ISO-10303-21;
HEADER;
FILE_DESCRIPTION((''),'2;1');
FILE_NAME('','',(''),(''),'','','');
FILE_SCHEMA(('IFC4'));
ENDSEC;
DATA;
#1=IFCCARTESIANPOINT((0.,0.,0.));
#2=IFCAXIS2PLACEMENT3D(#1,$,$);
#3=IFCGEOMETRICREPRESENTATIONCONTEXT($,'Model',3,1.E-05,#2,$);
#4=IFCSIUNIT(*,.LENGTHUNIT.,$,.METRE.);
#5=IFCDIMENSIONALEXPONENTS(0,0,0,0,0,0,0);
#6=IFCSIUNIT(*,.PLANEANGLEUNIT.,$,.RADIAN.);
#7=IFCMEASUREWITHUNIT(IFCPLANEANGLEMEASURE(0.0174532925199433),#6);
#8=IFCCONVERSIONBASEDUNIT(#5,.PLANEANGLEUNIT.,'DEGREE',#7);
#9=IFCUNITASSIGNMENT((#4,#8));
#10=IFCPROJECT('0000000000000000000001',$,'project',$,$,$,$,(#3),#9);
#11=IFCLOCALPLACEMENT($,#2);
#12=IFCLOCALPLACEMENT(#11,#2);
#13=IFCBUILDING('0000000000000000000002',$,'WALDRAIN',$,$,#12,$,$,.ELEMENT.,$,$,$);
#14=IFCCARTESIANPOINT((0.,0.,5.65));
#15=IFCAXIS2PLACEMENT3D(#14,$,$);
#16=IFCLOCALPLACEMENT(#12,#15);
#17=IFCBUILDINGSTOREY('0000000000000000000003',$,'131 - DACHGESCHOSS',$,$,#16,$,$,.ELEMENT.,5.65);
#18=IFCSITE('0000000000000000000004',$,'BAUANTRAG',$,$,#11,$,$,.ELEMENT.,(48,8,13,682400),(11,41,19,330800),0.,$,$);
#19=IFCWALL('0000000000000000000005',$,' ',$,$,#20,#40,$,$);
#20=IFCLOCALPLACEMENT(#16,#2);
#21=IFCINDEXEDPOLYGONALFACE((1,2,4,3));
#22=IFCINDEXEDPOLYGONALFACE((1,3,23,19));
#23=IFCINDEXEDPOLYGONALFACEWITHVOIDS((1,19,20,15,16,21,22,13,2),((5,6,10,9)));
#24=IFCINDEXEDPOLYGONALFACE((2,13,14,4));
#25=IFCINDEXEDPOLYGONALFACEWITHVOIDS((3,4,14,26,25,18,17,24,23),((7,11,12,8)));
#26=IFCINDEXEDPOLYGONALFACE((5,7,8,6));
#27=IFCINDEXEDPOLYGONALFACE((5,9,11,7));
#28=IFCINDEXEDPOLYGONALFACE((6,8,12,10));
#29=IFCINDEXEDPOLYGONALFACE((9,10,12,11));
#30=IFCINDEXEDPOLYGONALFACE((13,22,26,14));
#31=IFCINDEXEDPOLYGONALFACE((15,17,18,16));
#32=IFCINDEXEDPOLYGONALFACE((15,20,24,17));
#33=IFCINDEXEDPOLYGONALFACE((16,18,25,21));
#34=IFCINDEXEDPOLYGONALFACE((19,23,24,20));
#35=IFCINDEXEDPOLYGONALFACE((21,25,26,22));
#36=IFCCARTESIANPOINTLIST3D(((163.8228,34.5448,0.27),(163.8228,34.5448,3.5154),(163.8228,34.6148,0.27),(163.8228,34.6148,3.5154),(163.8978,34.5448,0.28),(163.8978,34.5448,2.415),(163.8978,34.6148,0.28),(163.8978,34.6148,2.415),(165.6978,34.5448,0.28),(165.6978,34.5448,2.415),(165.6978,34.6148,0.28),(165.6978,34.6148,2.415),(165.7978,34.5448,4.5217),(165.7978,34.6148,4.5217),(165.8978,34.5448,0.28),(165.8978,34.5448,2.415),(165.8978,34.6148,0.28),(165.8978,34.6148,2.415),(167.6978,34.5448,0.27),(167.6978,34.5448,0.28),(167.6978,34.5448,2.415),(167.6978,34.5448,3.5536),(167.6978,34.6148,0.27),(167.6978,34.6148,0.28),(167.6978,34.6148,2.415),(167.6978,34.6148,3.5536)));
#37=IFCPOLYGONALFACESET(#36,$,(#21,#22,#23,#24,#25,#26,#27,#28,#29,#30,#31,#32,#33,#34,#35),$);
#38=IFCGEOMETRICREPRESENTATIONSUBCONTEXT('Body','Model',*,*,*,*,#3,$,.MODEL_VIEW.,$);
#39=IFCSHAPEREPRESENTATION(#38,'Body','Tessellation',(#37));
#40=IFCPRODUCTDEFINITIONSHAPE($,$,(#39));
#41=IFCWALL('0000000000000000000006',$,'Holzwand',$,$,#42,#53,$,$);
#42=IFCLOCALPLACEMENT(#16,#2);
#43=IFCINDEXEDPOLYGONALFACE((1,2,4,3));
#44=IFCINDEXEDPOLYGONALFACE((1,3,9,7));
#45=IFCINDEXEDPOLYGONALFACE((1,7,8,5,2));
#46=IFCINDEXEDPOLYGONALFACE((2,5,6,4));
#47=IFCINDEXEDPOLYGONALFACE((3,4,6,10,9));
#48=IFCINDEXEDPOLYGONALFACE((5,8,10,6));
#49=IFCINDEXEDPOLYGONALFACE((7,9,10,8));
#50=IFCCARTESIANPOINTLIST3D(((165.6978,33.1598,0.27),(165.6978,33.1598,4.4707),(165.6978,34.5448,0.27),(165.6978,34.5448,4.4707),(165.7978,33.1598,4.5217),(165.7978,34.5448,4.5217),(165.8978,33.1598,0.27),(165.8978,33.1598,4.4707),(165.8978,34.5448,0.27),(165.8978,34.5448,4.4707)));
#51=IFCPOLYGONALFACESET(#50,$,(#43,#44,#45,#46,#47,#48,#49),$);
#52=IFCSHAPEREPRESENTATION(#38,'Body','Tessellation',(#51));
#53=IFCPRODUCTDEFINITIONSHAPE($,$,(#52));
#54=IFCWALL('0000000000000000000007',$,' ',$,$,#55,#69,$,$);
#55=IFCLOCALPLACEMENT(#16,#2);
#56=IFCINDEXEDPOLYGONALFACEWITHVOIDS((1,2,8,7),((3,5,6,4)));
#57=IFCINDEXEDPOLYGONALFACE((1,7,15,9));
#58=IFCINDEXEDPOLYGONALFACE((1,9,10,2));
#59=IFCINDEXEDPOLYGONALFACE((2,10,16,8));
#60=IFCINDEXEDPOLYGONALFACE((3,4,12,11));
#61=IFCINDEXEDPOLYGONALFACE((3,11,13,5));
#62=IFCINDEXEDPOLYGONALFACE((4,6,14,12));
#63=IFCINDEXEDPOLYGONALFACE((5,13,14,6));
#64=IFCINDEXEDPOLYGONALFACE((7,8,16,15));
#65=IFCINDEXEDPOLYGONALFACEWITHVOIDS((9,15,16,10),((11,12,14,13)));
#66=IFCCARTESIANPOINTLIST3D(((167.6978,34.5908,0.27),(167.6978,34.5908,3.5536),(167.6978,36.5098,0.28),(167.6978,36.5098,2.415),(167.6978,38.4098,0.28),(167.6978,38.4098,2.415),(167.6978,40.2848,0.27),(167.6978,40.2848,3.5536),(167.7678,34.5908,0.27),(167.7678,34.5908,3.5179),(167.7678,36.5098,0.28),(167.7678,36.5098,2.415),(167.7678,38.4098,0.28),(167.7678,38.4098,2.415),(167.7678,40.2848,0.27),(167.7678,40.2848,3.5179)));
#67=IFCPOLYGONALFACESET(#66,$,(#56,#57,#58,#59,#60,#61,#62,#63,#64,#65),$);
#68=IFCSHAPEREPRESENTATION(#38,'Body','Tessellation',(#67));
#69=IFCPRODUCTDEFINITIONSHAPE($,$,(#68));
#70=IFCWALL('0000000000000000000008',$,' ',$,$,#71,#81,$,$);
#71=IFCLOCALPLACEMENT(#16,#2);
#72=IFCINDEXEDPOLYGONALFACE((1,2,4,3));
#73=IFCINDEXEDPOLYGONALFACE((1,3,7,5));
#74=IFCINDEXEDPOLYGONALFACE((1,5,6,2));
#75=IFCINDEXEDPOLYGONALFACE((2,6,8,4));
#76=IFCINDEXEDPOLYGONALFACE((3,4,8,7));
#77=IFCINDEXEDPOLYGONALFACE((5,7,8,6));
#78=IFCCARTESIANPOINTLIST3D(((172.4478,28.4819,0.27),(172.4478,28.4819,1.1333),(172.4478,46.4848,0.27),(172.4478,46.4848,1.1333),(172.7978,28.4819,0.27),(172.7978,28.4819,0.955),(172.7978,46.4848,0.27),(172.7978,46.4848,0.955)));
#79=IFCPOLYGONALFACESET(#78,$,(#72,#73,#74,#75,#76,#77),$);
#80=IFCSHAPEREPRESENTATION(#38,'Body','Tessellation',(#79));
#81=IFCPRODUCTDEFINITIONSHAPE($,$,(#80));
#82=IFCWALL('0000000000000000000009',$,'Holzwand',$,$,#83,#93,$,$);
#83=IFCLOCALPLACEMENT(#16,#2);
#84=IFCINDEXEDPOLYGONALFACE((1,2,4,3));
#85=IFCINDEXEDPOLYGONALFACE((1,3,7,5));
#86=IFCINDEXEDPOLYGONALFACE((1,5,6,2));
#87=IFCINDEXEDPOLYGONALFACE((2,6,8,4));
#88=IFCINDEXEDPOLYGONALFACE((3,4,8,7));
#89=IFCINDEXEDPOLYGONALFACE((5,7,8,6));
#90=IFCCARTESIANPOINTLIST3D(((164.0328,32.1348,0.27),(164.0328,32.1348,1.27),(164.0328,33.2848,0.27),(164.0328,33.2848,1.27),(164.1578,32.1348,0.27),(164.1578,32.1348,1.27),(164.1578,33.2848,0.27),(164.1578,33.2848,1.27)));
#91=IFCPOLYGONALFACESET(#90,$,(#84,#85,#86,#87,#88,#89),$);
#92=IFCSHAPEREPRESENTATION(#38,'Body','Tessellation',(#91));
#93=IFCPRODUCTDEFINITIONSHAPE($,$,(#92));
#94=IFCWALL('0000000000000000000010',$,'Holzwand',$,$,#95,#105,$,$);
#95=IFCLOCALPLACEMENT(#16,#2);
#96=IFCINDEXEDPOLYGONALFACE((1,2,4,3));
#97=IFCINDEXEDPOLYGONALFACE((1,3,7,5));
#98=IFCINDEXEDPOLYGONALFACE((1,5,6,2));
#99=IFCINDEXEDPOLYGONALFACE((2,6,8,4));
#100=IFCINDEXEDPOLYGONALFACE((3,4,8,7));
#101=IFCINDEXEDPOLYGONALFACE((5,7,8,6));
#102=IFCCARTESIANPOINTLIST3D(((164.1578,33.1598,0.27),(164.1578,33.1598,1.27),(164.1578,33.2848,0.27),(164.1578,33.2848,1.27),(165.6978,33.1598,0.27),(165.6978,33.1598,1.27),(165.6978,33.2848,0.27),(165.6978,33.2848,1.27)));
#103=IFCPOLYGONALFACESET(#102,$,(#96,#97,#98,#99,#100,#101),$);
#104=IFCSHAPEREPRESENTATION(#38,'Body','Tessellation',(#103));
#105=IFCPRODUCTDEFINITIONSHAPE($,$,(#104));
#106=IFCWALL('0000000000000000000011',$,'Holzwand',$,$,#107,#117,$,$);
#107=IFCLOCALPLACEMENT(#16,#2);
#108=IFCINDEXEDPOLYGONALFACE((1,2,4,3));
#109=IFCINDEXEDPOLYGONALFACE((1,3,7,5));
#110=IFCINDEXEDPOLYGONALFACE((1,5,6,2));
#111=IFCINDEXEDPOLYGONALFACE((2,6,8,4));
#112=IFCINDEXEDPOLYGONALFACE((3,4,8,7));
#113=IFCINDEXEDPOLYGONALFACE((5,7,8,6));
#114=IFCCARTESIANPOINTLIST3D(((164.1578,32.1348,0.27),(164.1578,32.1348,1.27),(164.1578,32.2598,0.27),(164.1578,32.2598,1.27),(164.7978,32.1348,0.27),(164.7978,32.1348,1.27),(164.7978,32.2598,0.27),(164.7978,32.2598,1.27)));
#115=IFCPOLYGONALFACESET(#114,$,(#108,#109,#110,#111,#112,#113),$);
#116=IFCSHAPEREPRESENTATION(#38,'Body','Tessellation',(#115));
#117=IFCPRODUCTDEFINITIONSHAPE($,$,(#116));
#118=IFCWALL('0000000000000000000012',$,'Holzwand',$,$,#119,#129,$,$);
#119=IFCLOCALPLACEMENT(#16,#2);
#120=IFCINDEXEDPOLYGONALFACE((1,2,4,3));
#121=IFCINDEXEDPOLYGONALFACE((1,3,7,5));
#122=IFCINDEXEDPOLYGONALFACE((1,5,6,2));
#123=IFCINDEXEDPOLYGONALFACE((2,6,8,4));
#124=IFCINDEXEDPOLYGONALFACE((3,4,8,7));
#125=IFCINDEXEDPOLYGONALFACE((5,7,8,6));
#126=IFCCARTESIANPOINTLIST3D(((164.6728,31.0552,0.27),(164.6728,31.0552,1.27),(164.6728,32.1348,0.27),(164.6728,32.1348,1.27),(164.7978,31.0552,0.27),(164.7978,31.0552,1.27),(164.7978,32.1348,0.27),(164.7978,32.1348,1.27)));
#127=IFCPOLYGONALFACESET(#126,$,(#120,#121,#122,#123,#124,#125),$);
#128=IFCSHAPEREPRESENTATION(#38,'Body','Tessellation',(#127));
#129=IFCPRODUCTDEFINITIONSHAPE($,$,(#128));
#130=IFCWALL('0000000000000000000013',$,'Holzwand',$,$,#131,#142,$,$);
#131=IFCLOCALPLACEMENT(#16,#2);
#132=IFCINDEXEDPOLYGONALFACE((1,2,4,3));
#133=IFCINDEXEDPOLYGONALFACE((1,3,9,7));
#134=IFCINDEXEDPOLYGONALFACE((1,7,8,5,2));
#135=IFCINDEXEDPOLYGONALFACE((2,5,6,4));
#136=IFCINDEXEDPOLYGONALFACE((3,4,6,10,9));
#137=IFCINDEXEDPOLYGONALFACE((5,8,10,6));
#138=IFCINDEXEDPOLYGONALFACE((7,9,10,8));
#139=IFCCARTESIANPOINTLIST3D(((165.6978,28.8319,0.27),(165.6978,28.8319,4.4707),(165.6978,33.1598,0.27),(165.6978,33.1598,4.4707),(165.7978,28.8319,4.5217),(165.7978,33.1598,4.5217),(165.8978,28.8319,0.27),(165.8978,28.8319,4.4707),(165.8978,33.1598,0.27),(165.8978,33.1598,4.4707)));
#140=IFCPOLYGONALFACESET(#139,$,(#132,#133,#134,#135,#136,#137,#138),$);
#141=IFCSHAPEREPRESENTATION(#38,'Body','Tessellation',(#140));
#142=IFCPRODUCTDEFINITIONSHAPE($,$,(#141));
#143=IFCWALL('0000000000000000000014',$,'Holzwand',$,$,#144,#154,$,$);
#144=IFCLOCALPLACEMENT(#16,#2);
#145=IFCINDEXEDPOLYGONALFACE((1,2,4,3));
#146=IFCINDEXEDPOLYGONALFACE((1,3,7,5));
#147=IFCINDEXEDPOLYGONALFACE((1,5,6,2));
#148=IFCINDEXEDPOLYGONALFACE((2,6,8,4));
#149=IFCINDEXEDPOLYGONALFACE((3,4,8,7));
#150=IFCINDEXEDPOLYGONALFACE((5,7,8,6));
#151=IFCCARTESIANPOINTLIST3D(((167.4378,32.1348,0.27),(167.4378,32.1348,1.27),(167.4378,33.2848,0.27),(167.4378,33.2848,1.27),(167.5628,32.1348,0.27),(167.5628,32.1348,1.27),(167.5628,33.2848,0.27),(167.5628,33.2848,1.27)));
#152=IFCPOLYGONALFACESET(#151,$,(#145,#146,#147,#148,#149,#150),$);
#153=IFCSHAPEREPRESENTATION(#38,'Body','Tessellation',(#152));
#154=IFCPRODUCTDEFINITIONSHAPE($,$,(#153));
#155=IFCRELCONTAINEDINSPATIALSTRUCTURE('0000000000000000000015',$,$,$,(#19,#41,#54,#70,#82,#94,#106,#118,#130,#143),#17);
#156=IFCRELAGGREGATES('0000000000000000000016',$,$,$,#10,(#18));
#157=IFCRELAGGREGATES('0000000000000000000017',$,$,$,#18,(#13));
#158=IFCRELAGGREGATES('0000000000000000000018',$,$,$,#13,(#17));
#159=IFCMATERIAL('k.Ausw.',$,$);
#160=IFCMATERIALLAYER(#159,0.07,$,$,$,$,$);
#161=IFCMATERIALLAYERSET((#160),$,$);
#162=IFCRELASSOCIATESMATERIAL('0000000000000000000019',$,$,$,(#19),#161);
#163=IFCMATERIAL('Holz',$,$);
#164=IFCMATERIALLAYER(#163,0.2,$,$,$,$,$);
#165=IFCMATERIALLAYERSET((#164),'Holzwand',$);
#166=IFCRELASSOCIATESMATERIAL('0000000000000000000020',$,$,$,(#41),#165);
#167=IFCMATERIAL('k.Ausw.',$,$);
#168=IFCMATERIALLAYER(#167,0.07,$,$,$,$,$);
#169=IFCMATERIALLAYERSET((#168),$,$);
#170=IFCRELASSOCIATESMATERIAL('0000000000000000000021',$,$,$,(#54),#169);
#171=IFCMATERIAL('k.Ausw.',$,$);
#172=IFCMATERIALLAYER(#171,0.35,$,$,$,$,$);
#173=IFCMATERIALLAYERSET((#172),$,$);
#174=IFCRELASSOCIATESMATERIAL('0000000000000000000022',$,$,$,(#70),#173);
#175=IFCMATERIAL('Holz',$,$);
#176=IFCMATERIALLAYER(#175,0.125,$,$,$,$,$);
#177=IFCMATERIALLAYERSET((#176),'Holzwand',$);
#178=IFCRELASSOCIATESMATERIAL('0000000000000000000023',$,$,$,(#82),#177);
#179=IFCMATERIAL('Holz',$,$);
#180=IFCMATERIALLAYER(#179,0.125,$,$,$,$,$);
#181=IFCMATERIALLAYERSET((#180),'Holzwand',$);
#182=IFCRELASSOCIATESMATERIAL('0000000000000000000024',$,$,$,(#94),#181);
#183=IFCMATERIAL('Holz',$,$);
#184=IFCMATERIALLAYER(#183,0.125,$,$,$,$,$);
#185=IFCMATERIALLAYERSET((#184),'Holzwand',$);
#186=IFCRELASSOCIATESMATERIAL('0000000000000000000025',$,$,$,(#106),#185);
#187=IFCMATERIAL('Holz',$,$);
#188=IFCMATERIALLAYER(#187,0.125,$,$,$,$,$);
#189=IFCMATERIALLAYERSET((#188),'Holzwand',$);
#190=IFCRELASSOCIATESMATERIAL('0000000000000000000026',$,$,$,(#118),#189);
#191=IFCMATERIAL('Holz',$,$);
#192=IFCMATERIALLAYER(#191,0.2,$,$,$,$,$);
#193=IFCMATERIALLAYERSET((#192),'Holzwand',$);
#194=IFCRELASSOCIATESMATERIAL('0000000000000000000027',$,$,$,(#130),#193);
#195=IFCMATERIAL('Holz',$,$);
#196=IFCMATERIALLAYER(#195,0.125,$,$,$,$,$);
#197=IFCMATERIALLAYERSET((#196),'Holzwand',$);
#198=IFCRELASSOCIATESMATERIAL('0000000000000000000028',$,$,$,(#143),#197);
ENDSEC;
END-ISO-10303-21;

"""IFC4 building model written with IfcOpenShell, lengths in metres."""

from ifc_helpers import new_model, entity, si_unit, converted_unit, frame, frame_2d, origin, origin_with_axes, place, context, subcontext, project, spatial, polyline, rectangle, outline, extrude, clip, halfspace, bounded_halfspace, material, layer, layer_set, layer_usage, element, save


model = new_model("IFC4")

# Units and contexts
model_context = context("Model", 3, precision=1e-05, world=origin())
body_context = subcontext(model_context, "Body", "Model", "MODEL_VIEW")
ifc_project = project(units=[si_unit("LENGTHUNIT", "METRE"), converted_unit("PLANEANGLEUNIT", "DEGREE", entity("IfcPlaneAngleMeasure", 0.0174532925199433), si_unit("PLANEANGLEUNIT", "RADIAN"), dimensions=[0, 0, 0, 0, 0, 0, 0])], contexts=[model_context])

# Site, building, storey
site_placement = place(None, origin())
site = spatial("IfcSite", under=ifc_project, at=site_placement, Name="BAUANTRAG", CompositionType="ELEMENT", RefLatitude=(48, 8, 13, 682400), RefLongitude=(11, 41, 19, 330800), RefElevation=0.0)
building_placement = place(site_placement, origin())
building = spatial("IfcBuilding", under=site, at=building_placement, Name="WALDRAIN", CompositionType="ELEMENT")
storey_placement = place(building_placement, frame((0.0, 0.0, 5.65)))
storey = spatial("IfcBuildingStorey", under=building, at=storey_placement, Name="131 - DACHGESCHOSS", CompositionType="ELEMENT", Elevation=5.65)

# Wall, openings
ifc_material_1 = material(Name="k.Ausw.")
ifc_layer_1 = layer(ifc_material_1, 0.07)
ifc_layer_set_1 = layer_set([ifc_layer_1])
ifc_layer_usage_1 = layer_usage(ifc_layer_set_1, "AXIS2", "POSITIVE", 0.0)
wall_1_placement = place(storey_placement, frame((163.8228, 34.5448, 0.27)))
wall_1 = element("IfcWall", 1, at=wall_1_placement, inside=storey, material=ifc_layer_usage_1, Name=" ", context=body_context, shape_type="Clipping", body=[
    clip(clip(extrude(rectangle(XDim=3.875, YDim=0.07, at=frame_2d((1.9375, 0.035), x_axis=(1.0, 0.0))), origin_with_axes(), (0.0, 0.0, 1.0), 4.2517), bounded_halfspace(frame((0.9875, 0.035, 3.7485), z_axis=(0.45399, 0.0, -0.891007), x_axis=(0.891007, 0.0, 0.45399)), True, origin_with_axes(), polyline([(0.0, 0.0), (1.975, 0.0), (1.975, 0.07), (0.0, 0.07), (0.0, 0.0)]))), bounded_halfspace(frame((2.925, 0.035, 3.7676), z_axis=(-0.45399, 0.0, -0.891007), x_axis=(-0.891007, 0.0, 0.45399)), True, origin_with_axes(), polyline([(3.875, 0.07), (1.975, 0.07), (1.975, 0.0), (3.875, 0.0), (3.875, 0.07)]))),
])
opening_1_placement = place(wall_1_placement, frame((0.075, 0.0, 0.01), z_axis=(0.0, 1.0, 0.0), x_axis=(0.0, 0.0, 1.0)))
element("IfcOpeningElement", 2, at=opening_1_placement, cuts=wall_1, ObjectType="Opening", context=body_context, shape_type="SweptSolid", body=[
    extrude(outline(polyline([(0.0, 1.8), (2.135, 1.8), (2.135, 0.0), (0.0, 0.0), (0.0, 1.8)])), origin_with_axes(), (0.0, 0.0, 1.0), 0.07),
])
opening_2_placement = place(wall_1_placement, frame((2.075, 0.0, 0.01), z_axis=(0.0, 1.0, 0.0), x_axis=(0.0, 0.0, 1.0)))
element("IfcOpeningElement", 3, at=opening_2_placement, cuts=wall_1, ObjectType="Opening", context=body_context, shape_type="SweptSolid", body=[
    extrude(outline(polyline([(0.0, 1.8), (2.135, 1.8), (2.135, 0.0), (0.0, 0.0), (0.0, 1.8)])), origin_with_axes(), (0.0, 0.0, 1.0), 0.07),
])

# Wall
ifc_material_2 = material(Name="Holz")
ifc_layer_2 = layer(ifc_material_2, 0.2)
ifc_layer_set_2 = layer_set([ifc_layer_2], Name="Holzwand")
ifc_layer_usage_2 = layer_usage(ifc_layer_set_2, "AXIS2", "POSITIVE", 0.0)
wall_2_placement = place(storey_placement, frame((165.6978, 34.5448, 0.27), z_axis=(0.0, 0.0, 1.0), x_axis=(0.0, -1.0, 0.0)))
element("IfcWall", 4, at=wall_2_placement, inside=storey, material=ifc_layer_usage_2, Name="Holzwand", context=body_context, shape_type="Clipping", body=[
    clip(clip(extrude(rectangle(XDim=1.385, YDim=0.2, at=frame_2d((0.6925, 0.1), x_axis=(1.0, 0.0))), origin_with_axes(), (0.0, 0.0, 1.0), 4.2517), bounded_halfspace(frame((0.6925, 0.05, 4.2262), z_axis=(0.0, 0.45399, -0.891007), x_axis=(0.0, 0.891007, 0.45399)), True, origin_with_axes(), polyline([(1.385, 0.0), (1.385, 0.1), (0.0, 0.1), (0.0, 0.0), (1.385, 0.0)]))), bounded_halfspace(frame((0.6925, 0.15, 4.2262), z_axis=(0.0, -0.45399, -0.891007), x_axis=(0.0, -0.891007, 0.45399)), True, origin_with_axes(), polyline([(0.0, 0.2), (0.0, 0.1), (1.385, 0.1), (1.385, 0.2), (0.0, 0.2)]))),
])

# Wall, opening
ifc_material_3 = material(Name="k.Ausw.")
ifc_layer_3 = layer(ifc_material_3, 0.07)
ifc_layer_set_3 = layer_set([ifc_layer_3])
ifc_layer_usage_3 = layer_usage(ifc_layer_set_3, "AXIS2", "POSITIVE", -0.07)
wall_3_placement = place(storey_placement, frame((167.7678, 34.5908, 0.27), z_axis=(0.0, 0.0, 1.0), x_axis=(0.0, 1.0, 0.0)))
wall_3 = element("IfcWall", 5, at=wall_3_placement, inside=storey, material=ifc_layer_usage_3, Name=" ", context=body_context, shape_type="Clipping", body=[
    clip(extrude(rectangle(XDim=5.694, YDim=0.07, at=frame_2d((2.847, 0.035), x_axis=(1.0, 0.0))), origin_with_axes(), (0.0, 0.0, 1.0), 3.2836), halfspace(frame((2.847, 0.035, 3.2657), z_axis=(0.0, 0.45399, -0.891007), x_axis=(1.0, 0.0, 0.0)), True)),
])
opening_3_placement = place(wall_3_placement, frame((3.819, 0.07, 0.01), z_axis=(0.0, -1.0, 0.0), x_axis=(0.0, 0.0, 1.0)))
element("IfcOpeningElement", 6, at=opening_3_placement, cuts=wall_3, ObjectType="Opening", context=body_context, shape_type="SweptSolid", body=[
    extrude(outline(polyline([(0.0, 1.9), (2.135, 1.9), (2.135, 0.0), (0.0, 0.0), (0.0, 1.9)])), origin_with_axes(), (0.0, 0.0, 1.0), 0.07),
])

# Walls
ifc_material_4 = material(Name="k.Ausw.")
ifc_layer_4 = layer(ifc_material_4, 0.35)
ifc_layer_set_4 = layer_set([ifc_layer_4])
ifc_layer_usage_4 = layer_usage(ifc_layer_set_4, "AXIS2", "POSITIVE", 0.0)
wall_4_placement = place(storey_placement, frame((172.7978, 28.4819, 0.27), z_axis=(0.0, 0.0, 1.0), x_axis=(0.0, 1.0, 0.0)))
element("IfcWall", 7, at=wall_4_placement, inside=storey, material=ifc_layer_usage_4, Name=" ", context=body_context, shape_type="Clipping", body=[
    clip(extrude(rectangle(XDim=18.0029, YDim=0.35, at=frame_2d((9.0014, 0.175), x_axis=(1.0, 0.0))), origin_with_axes(), (0.0, 0.0, 1.0), 0.8633), halfspace(frame((9.0014, 0.175, 0.7742), z_axis=(0.0, 0.45399, -0.891007), x_axis=(0.0, -0.891007, -0.45399)), True)),
])
ifc_material_5 = material(Name="Holz")
ifc_layer_5 = layer(ifc_material_5, 0.125)
ifc_layer_set_5 = layer_set([ifc_layer_5], Name="Holzwand")
ifc_layer_usage_5 = layer_usage(ifc_layer_set_5, "AXIS2", "POSITIVE", 0.0)
wall_5_placement = place(storey_placement, frame((164.1578, 32.1348, 0.27), z_axis=(0.0, 0.0, 1.0), x_axis=(0.0, 1.0, 0.0)))
element("IfcWall", 8, at=wall_5_placement, inside=storey, material=ifc_layer_usage_5, Name="Holzwand", context=body_context, shape_type="SweptSolid", body=[
    extrude(rectangle(XDim=1.15, YDim=0.125, at=frame_2d((0.575, 0.0625), x_axis=(1.0, 0.0))), origin_with_axes(), (0.0, 0.0, 1.0), 1.0),
])
ifc_material_6 = material(Name="Holz")
ifc_layer_6 = layer(ifc_material_6, 0.125)
ifc_layer_set_6 = layer_set([ifc_layer_6], Name="Holzwand")
ifc_layer_usage_6 = layer_usage(ifc_layer_set_6, "AXIS2", "POSITIVE", 0.0)
wall_6_placement = place(storey_placement, frame((164.1578, 33.1598, 0.27)))
element("IfcWall", 9, at=wall_6_placement, inside=storey, material=ifc_layer_usage_6, Name="Holzwand", context=body_context, shape_type="SweptSolid", body=[
    extrude(rectangle(XDim=1.54, YDim=0.125, at=frame_2d((0.77, 0.0625), x_axis=(1.0, 0.0))), origin_with_axes(), (0.0, 0.0, 1.0), 1.0),
])
ifc_material_7 = material(Name="Holz")
ifc_layer_7 = layer(ifc_material_7, 0.125)
ifc_layer_set_7 = layer_set([ifc_layer_7], Name="Holzwand")
ifc_layer_usage_7 = layer_usage(ifc_layer_set_7, "AXIS2", "POSITIVE", 0.0)
wall_7_placement = place(storey_placement, frame((164.7978, 32.2598, 0.27), z_axis=(0.0, 0.0, 1.0), x_axis=(-1.0, 0.0, 0.0)))
element("IfcWall", 10, at=wall_7_placement, inside=storey, material=ifc_layer_usage_7, Name="Holzwand", context=body_context, shape_type="SweptSolid", body=[
    extrude(rectangle(XDim=0.64, YDim=0.125, at=frame_2d((0.32, 0.0625), x_axis=(1.0, 0.0))), origin_with_axes(), (0.0, 0.0, 1.0), 1.0),
])
ifc_material_8 = material(Name="Holz")
ifc_layer_8 = layer(ifc_material_8, 0.125)
ifc_layer_set_8 = layer_set([ifc_layer_8], Name="Holzwand")
ifc_layer_usage_8 = layer_usage(ifc_layer_set_8, "AXIS2", "POSITIVE", 0.0)
wall_8_placement = place(storey_placement, frame((164.7978, 31.0552, 0.27), z_axis=(0.0, 0.0, 1.0), x_axis=(0.0, 1.0, 0.0)))
element("IfcWall", 11, at=wall_8_placement, inside=storey, material=ifc_layer_usage_8, Name="Holzwand", context=body_context, shape_type="SweptSolid", body=[
    extrude(rectangle(XDim=1.0796, YDim=0.125, at=frame_2d((0.5398, 0.0625), x_axis=(1.0, 0.0))), origin_with_axes(), (0.0, 0.0, 1.0), 1.0),
])
ifc_material_9 = material(Name="Holz")
ifc_layer_9 = layer(ifc_material_9, 0.2)
ifc_layer_set_9 = layer_set([ifc_layer_9], Name="Holzwand")
ifc_layer_usage_9 = layer_usage(ifc_layer_set_9, "AXIS2", "POSITIVE", 0.0)
wall_9_placement = place(storey_placement, frame((165.6978, 33.1598, 0.27), z_axis=(0.0, 0.0, 1.0), x_axis=(0.0, -1.0, 0.0)))
element("IfcWall", 12, at=wall_9_placement, inside=storey, material=ifc_layer_usage_9, Name="Holzwand", context=body_context, shape_type="Clipping", body=[
    clip(clip(extrude(rectangle(XDim=4.3279, YDim=0.2, at=frame_2d((2.1639, 0.1), x_axis=(1.0, 0.0))), origin_with_axes(), (0.0, 0.0, 1.0), 4.2517), bounded_halfspace(frame((2.1639, 0.05, 4.2262), z_axis=(0.0, 0.45399, -0.891007), x_axis=(0.0, 0.891007, 0.45399)), True, origin_with_axes(), polyline([(4.3279, 0.0), (4.3279, 0.1), (0.0, 0.1), (0.0, 0.0), (4.3279, 0.0)]))), bounded_halfspace(frame((2.1639, 0.15, 4.2262), z_axis=(0.0, -0.45399, -0.891007), x_axis=(0.0, -0.891007, 0.45399)), True, origin_with_axes(), polyline([(0.0, 0.2), (0.0, 0.1), (4.3279, 0.1), (4.3279, 0.2), (0.0, 0.2)]))),
])
ifc_material_10 = material(Name="Holz")
ifc_layer_10 = layer(ifc_material_10, 0.125)
ifc_layer_set_10 = layer_set([ifc_layer_10], Name="Holzwand")
ifc_layer_usage_10 = layer_usage(ifc_layer_set_10, "AXIS2", "POSITIVE", 0.0)
wall_10_placement = place(storey_placement, frame((167.4378, 33.2848, 0.27), z_axis=(0.0, 0.0, 1.0), x_axis=(0.0, -1.0, 0.0)))
element("IfcWall", 13, at=wall_10_placement, inside=storey, material=ifc_layer_usage_10, Name="Holzwand", context=body_context, shape_type="SweptSolid", body=[
    extrude(rectangle(XDim=1.15, YDim=0.125, at=frame_2d((0.575, 0.0625), x_axis=(1.0, 0.0))), origin_with_axes(), (0.0, 0.0, 1.0), 1.0),
])

save(model, "model.ifc")
